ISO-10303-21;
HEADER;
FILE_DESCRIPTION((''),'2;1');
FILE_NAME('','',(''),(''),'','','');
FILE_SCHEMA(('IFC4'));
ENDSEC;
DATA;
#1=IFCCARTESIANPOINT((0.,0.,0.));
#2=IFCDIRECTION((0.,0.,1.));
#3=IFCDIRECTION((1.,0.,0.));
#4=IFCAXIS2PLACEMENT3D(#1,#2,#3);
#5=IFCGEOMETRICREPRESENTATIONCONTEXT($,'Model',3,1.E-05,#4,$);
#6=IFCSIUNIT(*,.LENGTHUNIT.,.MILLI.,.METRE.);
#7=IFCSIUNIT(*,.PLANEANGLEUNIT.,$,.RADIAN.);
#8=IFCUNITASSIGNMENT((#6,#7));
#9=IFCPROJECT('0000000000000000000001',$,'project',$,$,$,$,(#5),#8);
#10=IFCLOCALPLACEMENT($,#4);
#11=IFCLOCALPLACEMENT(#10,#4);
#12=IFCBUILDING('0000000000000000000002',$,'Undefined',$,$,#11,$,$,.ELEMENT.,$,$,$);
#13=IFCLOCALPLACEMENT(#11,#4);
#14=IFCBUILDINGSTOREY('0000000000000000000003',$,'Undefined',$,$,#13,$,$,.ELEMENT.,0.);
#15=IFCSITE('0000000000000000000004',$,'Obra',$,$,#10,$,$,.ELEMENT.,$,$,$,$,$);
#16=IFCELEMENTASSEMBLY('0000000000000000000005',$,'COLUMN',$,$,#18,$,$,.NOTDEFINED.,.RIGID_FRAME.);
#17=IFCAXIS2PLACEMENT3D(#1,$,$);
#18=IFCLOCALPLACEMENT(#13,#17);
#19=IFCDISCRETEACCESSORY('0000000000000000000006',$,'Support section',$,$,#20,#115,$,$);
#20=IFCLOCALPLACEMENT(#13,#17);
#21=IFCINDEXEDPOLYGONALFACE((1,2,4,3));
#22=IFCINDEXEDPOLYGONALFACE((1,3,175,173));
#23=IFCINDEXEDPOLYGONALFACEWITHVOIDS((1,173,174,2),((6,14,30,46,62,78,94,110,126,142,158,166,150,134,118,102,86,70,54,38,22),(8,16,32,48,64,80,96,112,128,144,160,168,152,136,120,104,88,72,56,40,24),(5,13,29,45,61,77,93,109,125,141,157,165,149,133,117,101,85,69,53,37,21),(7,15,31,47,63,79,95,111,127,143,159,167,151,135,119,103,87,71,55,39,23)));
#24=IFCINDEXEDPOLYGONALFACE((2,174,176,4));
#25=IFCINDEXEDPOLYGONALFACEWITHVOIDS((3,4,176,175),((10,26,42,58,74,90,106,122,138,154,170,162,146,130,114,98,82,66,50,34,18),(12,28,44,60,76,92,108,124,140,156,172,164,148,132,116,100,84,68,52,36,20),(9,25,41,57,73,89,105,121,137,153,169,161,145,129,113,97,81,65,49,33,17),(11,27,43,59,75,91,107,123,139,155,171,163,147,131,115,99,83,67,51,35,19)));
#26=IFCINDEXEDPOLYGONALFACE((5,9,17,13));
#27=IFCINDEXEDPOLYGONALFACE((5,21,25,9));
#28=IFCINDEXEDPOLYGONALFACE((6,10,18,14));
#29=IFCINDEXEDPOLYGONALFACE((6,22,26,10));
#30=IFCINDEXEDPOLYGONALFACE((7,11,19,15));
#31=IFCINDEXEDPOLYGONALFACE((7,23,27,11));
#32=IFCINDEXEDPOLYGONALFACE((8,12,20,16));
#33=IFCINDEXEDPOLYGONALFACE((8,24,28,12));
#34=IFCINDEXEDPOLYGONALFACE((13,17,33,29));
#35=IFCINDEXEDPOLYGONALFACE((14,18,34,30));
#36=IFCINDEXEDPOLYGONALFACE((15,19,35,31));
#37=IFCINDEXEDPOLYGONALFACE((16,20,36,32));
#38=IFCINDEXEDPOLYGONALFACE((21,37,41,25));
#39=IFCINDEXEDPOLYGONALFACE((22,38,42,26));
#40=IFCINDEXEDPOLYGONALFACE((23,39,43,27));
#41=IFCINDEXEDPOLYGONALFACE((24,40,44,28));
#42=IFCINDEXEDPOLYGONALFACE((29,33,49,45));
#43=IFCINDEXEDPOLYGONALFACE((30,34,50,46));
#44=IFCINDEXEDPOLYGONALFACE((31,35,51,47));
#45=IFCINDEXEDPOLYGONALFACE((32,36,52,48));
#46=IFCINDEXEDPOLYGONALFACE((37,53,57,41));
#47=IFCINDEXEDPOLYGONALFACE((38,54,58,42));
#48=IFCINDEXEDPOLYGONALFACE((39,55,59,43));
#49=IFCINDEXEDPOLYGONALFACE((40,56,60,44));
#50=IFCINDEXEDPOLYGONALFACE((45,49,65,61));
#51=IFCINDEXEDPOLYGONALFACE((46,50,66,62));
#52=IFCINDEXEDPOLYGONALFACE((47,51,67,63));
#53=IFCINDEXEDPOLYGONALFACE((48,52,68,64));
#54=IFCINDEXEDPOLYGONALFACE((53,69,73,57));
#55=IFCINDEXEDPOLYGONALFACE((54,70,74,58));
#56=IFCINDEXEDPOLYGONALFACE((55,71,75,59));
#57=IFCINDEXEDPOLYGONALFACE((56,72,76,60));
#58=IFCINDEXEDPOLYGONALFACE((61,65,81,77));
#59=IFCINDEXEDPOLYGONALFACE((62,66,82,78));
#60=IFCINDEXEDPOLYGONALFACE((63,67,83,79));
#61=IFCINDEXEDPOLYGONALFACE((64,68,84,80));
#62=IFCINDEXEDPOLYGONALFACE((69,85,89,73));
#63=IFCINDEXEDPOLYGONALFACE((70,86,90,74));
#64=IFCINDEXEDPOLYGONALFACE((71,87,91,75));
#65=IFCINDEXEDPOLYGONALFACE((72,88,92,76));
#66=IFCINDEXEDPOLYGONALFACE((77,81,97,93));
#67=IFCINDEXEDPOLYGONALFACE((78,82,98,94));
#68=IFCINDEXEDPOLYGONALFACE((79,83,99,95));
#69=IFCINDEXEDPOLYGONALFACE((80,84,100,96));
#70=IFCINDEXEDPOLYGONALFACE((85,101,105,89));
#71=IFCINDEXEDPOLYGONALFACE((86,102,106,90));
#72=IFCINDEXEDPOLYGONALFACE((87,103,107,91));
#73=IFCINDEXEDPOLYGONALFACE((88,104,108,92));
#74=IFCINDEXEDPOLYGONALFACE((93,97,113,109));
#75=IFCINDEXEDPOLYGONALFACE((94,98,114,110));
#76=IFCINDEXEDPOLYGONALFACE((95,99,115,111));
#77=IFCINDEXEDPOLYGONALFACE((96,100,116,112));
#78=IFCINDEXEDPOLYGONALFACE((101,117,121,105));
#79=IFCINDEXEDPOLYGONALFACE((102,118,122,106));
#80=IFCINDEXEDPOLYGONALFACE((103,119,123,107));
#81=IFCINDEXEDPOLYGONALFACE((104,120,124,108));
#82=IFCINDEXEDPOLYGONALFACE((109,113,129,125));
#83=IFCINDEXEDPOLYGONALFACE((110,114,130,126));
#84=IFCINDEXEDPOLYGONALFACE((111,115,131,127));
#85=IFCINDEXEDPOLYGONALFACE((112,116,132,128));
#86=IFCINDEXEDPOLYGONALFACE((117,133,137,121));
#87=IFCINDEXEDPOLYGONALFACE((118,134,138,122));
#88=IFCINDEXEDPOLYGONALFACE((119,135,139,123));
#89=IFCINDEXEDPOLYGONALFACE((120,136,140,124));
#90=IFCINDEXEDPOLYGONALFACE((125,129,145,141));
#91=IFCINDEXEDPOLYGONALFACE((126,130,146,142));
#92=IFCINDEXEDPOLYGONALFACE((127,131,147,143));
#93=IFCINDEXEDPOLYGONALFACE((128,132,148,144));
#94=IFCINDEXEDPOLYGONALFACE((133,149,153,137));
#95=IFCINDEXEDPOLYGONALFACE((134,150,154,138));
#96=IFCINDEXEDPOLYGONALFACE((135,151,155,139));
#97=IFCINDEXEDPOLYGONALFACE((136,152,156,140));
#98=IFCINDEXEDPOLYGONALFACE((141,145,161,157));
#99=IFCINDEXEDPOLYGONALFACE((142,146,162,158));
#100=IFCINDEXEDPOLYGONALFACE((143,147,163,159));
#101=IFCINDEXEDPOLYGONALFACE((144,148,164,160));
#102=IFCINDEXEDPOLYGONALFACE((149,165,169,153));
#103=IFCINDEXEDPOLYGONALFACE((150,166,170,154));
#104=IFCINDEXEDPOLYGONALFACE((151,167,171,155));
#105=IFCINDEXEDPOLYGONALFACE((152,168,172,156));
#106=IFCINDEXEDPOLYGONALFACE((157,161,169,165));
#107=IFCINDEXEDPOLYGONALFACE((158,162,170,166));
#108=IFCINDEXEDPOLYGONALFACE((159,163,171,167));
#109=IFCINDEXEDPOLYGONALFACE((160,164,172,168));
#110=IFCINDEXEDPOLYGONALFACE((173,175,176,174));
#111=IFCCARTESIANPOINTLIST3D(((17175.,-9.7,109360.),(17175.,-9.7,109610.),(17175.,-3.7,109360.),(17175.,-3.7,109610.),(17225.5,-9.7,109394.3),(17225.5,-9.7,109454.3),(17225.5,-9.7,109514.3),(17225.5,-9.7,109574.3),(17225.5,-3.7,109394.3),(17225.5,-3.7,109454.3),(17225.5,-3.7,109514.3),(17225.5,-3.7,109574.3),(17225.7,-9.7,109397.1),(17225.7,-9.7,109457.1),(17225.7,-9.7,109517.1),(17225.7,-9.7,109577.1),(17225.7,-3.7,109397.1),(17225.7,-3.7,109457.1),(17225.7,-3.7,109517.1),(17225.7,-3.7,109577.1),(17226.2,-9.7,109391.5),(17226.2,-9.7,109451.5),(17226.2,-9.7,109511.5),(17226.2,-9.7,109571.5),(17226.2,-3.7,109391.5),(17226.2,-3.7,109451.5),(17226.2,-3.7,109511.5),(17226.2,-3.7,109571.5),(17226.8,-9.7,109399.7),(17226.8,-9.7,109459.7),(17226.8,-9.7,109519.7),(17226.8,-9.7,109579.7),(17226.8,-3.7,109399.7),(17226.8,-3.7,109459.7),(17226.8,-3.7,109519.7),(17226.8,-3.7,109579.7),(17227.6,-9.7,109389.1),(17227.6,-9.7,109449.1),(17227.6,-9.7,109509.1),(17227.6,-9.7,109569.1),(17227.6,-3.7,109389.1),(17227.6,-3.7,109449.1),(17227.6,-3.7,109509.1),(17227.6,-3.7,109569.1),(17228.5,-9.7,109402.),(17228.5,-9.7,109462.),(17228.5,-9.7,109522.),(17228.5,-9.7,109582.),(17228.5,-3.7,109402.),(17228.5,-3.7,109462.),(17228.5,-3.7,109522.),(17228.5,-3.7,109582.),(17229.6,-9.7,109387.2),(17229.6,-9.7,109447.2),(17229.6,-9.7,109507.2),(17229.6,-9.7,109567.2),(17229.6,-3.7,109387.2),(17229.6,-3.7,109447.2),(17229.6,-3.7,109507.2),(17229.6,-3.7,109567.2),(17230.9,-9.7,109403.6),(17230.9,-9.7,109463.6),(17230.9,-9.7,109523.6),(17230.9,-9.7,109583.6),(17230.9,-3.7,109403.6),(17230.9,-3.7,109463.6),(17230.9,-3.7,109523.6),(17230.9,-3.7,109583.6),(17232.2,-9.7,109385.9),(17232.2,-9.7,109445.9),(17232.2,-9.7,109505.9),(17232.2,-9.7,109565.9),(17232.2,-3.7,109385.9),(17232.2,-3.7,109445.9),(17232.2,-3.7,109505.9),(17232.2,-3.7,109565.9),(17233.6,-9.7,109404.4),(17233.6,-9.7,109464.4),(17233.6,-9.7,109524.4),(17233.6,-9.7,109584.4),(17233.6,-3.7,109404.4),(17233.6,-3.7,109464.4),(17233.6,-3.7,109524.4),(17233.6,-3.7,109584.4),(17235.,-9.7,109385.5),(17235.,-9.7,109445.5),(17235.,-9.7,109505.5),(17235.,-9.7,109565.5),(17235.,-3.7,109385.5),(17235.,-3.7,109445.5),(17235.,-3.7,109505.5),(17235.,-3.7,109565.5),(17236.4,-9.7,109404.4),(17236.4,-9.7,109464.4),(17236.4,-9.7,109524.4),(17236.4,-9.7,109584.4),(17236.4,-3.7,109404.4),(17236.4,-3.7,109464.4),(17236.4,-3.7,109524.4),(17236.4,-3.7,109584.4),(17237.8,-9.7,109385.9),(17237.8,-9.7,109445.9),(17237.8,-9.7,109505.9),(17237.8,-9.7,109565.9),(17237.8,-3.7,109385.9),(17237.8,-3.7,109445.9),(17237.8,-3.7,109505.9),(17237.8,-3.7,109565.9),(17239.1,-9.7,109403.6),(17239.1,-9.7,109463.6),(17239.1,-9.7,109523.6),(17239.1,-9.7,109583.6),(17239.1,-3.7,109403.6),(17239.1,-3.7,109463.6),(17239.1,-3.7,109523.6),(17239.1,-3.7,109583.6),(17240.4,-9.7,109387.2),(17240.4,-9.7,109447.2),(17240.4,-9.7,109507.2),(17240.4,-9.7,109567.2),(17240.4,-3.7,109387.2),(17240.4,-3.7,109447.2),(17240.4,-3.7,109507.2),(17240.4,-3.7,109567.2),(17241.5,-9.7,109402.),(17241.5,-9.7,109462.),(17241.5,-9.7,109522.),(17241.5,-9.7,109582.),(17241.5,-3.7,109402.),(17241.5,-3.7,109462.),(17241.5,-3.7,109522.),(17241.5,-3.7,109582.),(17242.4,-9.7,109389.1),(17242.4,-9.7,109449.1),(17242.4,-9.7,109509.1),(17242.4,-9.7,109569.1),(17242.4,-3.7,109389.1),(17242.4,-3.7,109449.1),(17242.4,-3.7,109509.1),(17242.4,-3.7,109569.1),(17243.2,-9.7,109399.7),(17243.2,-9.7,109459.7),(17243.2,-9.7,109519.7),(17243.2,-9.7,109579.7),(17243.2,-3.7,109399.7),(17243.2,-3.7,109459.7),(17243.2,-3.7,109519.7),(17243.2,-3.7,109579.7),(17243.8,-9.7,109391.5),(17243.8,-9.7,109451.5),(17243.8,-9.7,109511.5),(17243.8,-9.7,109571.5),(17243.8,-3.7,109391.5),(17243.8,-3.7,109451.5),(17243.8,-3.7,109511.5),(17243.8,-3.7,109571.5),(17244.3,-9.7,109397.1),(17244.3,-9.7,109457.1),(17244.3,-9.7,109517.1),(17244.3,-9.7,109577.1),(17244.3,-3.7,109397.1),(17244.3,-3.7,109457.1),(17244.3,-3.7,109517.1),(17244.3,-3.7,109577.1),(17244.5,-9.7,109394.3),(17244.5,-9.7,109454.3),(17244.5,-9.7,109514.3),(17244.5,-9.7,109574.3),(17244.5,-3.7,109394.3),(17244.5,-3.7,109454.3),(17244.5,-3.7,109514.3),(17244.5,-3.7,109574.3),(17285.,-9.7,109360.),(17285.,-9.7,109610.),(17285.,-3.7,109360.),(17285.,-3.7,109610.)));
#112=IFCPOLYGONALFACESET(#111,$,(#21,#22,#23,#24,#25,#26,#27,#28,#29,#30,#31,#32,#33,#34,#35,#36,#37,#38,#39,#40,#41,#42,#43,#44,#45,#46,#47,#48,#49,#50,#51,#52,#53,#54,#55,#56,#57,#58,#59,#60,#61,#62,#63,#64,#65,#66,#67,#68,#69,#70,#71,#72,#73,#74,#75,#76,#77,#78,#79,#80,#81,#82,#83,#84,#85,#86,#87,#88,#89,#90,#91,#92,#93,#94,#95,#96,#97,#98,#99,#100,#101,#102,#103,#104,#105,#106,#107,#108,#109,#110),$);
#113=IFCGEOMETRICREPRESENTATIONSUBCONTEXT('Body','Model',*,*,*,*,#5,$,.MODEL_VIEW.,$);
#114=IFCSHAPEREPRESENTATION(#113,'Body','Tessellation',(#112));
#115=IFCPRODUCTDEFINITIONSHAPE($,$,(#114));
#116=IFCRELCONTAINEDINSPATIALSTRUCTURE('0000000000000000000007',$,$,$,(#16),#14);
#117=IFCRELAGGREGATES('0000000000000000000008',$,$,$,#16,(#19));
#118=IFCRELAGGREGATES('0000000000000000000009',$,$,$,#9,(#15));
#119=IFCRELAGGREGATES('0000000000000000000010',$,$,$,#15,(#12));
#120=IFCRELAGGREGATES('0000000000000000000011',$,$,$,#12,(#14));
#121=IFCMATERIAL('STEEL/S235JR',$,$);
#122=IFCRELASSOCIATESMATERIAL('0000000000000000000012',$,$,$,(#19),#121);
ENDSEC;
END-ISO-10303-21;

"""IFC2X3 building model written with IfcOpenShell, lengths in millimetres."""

from ifc_helpers import new_model, si_unit, frame, origin_with_axes, origin_2d_with_axis, place, context, subcontext, project, spatial, rectangle, circle, extrude, source, transform, mapped, material, element, aggregate, save


model = new_model("IFC2X3")

# Units and contexts
model_context = context("Model", 3, precision=1e-05, world=origin_with_axes())
body_context = subcontext(model_context, "Body", "Model", "MODEL_VIEW")
ifc_project = project(units=[si_unit("LENGTHUNIT", "METRE", prefix="MILLI"), si_unit("PLANEANGLEUNIT", "RADIAN")], contexts=[model_context])

# Site, building, storey
site_placement = place(None, origin_with_axes())
site = spatial("IfcSite", under=ifc_project, at=site_placement, Name="Obra", CompositionType="ELEMENT")
building_placement = place(site_placement, origin_with_axes())
building = spatial("IfcBuilding", under=site, at=building_placement, Name="Undefined", CompositionType="ELEMENT")
storey_placement = place(building_placement, origin_with_axes())
storey = spatial("IfcBuildingStorey", under=building, at=storey_placement, Name="Undefined", CompositionType="ELEMENT", Elevation=0.0)

# Element assembly, discrete accessory, opening
assembly_1_placement = place(storey_placement, origin_with_axes())
assembly_1 = element("IfcElementAssembly", 1, at=assembly_1_placement, inside=storey, Name="COLUMN", AssemblyPlace="NOTDEFINED", PredefinedType="RIGID_FRAME")
ifc_material_1 = material(Name="STEEL/S235JR")
shared_shape_1 = source(origin_with_axes(), body_context, "Body", "SweptSolid", [
    extrude(circle(Radius=9.5, at=origin_2d_with_axis()), frame((0.0, -9.8, 0.0), z_axis=(0.0, 1.0, 0.0), x_axis=(1.0, 0.0, 0.0)), (0.0, 0.0, 1.0), 6.2),
])
discrete_accessory_1_placement = place(assembly_1_placement, frame((17230.0, -6.7, 109360.0), z_axis=(0.0, 0.0, 1.0), x_axis=(-1.0, 0.0, 0.0)))
discrete_accessory_1 = element("IfcDiscreteAccessory", 2, at=discrete_accessory_1_placement, material=ifc_material_1, Name="Support section", context=body_context, shape_type="SweptSolid", body=[
    extrude(rectangle(XDim=6.0, YDim=110.0, at=origin_2d_with_axis()), frame((0.0, 0.0, 250.0), z_axis=(0.0, 0.0, -1.0), x_axis=(0.0, 1.0, 0.0)), (0.0, 0.0, 1.0), 250.0),
])
opening_1_placement = place(assembly_1_placement, frame((17185.0, 0.0, 109650.0), z_axis=(1.0, 0.0, 0.0), x_axis=(0.0, 0.0, -1.0)))
element("IfcOpeningElement", 3, at=opening_1_placement, cuts=discrete_accessory_1, ObjectType="Opening", context=body_context, shape_type="MappedRepresentation", body=[
    mapped(shared_shape_1, transform((75.0, 0.0, 50.0))),
    mapped(shared_shape_1, transform((135.0, 0.0, 50.0))),
    mapped(shared_shape_1, transform((195.0, 0.0, 50.0))),
    mapped(shared_shape_1, transform((255.0, 0.0, 50.0))),
])
aggregate(assembly_1, [discrete_accessory_1])

save(model, "model.ifc")
